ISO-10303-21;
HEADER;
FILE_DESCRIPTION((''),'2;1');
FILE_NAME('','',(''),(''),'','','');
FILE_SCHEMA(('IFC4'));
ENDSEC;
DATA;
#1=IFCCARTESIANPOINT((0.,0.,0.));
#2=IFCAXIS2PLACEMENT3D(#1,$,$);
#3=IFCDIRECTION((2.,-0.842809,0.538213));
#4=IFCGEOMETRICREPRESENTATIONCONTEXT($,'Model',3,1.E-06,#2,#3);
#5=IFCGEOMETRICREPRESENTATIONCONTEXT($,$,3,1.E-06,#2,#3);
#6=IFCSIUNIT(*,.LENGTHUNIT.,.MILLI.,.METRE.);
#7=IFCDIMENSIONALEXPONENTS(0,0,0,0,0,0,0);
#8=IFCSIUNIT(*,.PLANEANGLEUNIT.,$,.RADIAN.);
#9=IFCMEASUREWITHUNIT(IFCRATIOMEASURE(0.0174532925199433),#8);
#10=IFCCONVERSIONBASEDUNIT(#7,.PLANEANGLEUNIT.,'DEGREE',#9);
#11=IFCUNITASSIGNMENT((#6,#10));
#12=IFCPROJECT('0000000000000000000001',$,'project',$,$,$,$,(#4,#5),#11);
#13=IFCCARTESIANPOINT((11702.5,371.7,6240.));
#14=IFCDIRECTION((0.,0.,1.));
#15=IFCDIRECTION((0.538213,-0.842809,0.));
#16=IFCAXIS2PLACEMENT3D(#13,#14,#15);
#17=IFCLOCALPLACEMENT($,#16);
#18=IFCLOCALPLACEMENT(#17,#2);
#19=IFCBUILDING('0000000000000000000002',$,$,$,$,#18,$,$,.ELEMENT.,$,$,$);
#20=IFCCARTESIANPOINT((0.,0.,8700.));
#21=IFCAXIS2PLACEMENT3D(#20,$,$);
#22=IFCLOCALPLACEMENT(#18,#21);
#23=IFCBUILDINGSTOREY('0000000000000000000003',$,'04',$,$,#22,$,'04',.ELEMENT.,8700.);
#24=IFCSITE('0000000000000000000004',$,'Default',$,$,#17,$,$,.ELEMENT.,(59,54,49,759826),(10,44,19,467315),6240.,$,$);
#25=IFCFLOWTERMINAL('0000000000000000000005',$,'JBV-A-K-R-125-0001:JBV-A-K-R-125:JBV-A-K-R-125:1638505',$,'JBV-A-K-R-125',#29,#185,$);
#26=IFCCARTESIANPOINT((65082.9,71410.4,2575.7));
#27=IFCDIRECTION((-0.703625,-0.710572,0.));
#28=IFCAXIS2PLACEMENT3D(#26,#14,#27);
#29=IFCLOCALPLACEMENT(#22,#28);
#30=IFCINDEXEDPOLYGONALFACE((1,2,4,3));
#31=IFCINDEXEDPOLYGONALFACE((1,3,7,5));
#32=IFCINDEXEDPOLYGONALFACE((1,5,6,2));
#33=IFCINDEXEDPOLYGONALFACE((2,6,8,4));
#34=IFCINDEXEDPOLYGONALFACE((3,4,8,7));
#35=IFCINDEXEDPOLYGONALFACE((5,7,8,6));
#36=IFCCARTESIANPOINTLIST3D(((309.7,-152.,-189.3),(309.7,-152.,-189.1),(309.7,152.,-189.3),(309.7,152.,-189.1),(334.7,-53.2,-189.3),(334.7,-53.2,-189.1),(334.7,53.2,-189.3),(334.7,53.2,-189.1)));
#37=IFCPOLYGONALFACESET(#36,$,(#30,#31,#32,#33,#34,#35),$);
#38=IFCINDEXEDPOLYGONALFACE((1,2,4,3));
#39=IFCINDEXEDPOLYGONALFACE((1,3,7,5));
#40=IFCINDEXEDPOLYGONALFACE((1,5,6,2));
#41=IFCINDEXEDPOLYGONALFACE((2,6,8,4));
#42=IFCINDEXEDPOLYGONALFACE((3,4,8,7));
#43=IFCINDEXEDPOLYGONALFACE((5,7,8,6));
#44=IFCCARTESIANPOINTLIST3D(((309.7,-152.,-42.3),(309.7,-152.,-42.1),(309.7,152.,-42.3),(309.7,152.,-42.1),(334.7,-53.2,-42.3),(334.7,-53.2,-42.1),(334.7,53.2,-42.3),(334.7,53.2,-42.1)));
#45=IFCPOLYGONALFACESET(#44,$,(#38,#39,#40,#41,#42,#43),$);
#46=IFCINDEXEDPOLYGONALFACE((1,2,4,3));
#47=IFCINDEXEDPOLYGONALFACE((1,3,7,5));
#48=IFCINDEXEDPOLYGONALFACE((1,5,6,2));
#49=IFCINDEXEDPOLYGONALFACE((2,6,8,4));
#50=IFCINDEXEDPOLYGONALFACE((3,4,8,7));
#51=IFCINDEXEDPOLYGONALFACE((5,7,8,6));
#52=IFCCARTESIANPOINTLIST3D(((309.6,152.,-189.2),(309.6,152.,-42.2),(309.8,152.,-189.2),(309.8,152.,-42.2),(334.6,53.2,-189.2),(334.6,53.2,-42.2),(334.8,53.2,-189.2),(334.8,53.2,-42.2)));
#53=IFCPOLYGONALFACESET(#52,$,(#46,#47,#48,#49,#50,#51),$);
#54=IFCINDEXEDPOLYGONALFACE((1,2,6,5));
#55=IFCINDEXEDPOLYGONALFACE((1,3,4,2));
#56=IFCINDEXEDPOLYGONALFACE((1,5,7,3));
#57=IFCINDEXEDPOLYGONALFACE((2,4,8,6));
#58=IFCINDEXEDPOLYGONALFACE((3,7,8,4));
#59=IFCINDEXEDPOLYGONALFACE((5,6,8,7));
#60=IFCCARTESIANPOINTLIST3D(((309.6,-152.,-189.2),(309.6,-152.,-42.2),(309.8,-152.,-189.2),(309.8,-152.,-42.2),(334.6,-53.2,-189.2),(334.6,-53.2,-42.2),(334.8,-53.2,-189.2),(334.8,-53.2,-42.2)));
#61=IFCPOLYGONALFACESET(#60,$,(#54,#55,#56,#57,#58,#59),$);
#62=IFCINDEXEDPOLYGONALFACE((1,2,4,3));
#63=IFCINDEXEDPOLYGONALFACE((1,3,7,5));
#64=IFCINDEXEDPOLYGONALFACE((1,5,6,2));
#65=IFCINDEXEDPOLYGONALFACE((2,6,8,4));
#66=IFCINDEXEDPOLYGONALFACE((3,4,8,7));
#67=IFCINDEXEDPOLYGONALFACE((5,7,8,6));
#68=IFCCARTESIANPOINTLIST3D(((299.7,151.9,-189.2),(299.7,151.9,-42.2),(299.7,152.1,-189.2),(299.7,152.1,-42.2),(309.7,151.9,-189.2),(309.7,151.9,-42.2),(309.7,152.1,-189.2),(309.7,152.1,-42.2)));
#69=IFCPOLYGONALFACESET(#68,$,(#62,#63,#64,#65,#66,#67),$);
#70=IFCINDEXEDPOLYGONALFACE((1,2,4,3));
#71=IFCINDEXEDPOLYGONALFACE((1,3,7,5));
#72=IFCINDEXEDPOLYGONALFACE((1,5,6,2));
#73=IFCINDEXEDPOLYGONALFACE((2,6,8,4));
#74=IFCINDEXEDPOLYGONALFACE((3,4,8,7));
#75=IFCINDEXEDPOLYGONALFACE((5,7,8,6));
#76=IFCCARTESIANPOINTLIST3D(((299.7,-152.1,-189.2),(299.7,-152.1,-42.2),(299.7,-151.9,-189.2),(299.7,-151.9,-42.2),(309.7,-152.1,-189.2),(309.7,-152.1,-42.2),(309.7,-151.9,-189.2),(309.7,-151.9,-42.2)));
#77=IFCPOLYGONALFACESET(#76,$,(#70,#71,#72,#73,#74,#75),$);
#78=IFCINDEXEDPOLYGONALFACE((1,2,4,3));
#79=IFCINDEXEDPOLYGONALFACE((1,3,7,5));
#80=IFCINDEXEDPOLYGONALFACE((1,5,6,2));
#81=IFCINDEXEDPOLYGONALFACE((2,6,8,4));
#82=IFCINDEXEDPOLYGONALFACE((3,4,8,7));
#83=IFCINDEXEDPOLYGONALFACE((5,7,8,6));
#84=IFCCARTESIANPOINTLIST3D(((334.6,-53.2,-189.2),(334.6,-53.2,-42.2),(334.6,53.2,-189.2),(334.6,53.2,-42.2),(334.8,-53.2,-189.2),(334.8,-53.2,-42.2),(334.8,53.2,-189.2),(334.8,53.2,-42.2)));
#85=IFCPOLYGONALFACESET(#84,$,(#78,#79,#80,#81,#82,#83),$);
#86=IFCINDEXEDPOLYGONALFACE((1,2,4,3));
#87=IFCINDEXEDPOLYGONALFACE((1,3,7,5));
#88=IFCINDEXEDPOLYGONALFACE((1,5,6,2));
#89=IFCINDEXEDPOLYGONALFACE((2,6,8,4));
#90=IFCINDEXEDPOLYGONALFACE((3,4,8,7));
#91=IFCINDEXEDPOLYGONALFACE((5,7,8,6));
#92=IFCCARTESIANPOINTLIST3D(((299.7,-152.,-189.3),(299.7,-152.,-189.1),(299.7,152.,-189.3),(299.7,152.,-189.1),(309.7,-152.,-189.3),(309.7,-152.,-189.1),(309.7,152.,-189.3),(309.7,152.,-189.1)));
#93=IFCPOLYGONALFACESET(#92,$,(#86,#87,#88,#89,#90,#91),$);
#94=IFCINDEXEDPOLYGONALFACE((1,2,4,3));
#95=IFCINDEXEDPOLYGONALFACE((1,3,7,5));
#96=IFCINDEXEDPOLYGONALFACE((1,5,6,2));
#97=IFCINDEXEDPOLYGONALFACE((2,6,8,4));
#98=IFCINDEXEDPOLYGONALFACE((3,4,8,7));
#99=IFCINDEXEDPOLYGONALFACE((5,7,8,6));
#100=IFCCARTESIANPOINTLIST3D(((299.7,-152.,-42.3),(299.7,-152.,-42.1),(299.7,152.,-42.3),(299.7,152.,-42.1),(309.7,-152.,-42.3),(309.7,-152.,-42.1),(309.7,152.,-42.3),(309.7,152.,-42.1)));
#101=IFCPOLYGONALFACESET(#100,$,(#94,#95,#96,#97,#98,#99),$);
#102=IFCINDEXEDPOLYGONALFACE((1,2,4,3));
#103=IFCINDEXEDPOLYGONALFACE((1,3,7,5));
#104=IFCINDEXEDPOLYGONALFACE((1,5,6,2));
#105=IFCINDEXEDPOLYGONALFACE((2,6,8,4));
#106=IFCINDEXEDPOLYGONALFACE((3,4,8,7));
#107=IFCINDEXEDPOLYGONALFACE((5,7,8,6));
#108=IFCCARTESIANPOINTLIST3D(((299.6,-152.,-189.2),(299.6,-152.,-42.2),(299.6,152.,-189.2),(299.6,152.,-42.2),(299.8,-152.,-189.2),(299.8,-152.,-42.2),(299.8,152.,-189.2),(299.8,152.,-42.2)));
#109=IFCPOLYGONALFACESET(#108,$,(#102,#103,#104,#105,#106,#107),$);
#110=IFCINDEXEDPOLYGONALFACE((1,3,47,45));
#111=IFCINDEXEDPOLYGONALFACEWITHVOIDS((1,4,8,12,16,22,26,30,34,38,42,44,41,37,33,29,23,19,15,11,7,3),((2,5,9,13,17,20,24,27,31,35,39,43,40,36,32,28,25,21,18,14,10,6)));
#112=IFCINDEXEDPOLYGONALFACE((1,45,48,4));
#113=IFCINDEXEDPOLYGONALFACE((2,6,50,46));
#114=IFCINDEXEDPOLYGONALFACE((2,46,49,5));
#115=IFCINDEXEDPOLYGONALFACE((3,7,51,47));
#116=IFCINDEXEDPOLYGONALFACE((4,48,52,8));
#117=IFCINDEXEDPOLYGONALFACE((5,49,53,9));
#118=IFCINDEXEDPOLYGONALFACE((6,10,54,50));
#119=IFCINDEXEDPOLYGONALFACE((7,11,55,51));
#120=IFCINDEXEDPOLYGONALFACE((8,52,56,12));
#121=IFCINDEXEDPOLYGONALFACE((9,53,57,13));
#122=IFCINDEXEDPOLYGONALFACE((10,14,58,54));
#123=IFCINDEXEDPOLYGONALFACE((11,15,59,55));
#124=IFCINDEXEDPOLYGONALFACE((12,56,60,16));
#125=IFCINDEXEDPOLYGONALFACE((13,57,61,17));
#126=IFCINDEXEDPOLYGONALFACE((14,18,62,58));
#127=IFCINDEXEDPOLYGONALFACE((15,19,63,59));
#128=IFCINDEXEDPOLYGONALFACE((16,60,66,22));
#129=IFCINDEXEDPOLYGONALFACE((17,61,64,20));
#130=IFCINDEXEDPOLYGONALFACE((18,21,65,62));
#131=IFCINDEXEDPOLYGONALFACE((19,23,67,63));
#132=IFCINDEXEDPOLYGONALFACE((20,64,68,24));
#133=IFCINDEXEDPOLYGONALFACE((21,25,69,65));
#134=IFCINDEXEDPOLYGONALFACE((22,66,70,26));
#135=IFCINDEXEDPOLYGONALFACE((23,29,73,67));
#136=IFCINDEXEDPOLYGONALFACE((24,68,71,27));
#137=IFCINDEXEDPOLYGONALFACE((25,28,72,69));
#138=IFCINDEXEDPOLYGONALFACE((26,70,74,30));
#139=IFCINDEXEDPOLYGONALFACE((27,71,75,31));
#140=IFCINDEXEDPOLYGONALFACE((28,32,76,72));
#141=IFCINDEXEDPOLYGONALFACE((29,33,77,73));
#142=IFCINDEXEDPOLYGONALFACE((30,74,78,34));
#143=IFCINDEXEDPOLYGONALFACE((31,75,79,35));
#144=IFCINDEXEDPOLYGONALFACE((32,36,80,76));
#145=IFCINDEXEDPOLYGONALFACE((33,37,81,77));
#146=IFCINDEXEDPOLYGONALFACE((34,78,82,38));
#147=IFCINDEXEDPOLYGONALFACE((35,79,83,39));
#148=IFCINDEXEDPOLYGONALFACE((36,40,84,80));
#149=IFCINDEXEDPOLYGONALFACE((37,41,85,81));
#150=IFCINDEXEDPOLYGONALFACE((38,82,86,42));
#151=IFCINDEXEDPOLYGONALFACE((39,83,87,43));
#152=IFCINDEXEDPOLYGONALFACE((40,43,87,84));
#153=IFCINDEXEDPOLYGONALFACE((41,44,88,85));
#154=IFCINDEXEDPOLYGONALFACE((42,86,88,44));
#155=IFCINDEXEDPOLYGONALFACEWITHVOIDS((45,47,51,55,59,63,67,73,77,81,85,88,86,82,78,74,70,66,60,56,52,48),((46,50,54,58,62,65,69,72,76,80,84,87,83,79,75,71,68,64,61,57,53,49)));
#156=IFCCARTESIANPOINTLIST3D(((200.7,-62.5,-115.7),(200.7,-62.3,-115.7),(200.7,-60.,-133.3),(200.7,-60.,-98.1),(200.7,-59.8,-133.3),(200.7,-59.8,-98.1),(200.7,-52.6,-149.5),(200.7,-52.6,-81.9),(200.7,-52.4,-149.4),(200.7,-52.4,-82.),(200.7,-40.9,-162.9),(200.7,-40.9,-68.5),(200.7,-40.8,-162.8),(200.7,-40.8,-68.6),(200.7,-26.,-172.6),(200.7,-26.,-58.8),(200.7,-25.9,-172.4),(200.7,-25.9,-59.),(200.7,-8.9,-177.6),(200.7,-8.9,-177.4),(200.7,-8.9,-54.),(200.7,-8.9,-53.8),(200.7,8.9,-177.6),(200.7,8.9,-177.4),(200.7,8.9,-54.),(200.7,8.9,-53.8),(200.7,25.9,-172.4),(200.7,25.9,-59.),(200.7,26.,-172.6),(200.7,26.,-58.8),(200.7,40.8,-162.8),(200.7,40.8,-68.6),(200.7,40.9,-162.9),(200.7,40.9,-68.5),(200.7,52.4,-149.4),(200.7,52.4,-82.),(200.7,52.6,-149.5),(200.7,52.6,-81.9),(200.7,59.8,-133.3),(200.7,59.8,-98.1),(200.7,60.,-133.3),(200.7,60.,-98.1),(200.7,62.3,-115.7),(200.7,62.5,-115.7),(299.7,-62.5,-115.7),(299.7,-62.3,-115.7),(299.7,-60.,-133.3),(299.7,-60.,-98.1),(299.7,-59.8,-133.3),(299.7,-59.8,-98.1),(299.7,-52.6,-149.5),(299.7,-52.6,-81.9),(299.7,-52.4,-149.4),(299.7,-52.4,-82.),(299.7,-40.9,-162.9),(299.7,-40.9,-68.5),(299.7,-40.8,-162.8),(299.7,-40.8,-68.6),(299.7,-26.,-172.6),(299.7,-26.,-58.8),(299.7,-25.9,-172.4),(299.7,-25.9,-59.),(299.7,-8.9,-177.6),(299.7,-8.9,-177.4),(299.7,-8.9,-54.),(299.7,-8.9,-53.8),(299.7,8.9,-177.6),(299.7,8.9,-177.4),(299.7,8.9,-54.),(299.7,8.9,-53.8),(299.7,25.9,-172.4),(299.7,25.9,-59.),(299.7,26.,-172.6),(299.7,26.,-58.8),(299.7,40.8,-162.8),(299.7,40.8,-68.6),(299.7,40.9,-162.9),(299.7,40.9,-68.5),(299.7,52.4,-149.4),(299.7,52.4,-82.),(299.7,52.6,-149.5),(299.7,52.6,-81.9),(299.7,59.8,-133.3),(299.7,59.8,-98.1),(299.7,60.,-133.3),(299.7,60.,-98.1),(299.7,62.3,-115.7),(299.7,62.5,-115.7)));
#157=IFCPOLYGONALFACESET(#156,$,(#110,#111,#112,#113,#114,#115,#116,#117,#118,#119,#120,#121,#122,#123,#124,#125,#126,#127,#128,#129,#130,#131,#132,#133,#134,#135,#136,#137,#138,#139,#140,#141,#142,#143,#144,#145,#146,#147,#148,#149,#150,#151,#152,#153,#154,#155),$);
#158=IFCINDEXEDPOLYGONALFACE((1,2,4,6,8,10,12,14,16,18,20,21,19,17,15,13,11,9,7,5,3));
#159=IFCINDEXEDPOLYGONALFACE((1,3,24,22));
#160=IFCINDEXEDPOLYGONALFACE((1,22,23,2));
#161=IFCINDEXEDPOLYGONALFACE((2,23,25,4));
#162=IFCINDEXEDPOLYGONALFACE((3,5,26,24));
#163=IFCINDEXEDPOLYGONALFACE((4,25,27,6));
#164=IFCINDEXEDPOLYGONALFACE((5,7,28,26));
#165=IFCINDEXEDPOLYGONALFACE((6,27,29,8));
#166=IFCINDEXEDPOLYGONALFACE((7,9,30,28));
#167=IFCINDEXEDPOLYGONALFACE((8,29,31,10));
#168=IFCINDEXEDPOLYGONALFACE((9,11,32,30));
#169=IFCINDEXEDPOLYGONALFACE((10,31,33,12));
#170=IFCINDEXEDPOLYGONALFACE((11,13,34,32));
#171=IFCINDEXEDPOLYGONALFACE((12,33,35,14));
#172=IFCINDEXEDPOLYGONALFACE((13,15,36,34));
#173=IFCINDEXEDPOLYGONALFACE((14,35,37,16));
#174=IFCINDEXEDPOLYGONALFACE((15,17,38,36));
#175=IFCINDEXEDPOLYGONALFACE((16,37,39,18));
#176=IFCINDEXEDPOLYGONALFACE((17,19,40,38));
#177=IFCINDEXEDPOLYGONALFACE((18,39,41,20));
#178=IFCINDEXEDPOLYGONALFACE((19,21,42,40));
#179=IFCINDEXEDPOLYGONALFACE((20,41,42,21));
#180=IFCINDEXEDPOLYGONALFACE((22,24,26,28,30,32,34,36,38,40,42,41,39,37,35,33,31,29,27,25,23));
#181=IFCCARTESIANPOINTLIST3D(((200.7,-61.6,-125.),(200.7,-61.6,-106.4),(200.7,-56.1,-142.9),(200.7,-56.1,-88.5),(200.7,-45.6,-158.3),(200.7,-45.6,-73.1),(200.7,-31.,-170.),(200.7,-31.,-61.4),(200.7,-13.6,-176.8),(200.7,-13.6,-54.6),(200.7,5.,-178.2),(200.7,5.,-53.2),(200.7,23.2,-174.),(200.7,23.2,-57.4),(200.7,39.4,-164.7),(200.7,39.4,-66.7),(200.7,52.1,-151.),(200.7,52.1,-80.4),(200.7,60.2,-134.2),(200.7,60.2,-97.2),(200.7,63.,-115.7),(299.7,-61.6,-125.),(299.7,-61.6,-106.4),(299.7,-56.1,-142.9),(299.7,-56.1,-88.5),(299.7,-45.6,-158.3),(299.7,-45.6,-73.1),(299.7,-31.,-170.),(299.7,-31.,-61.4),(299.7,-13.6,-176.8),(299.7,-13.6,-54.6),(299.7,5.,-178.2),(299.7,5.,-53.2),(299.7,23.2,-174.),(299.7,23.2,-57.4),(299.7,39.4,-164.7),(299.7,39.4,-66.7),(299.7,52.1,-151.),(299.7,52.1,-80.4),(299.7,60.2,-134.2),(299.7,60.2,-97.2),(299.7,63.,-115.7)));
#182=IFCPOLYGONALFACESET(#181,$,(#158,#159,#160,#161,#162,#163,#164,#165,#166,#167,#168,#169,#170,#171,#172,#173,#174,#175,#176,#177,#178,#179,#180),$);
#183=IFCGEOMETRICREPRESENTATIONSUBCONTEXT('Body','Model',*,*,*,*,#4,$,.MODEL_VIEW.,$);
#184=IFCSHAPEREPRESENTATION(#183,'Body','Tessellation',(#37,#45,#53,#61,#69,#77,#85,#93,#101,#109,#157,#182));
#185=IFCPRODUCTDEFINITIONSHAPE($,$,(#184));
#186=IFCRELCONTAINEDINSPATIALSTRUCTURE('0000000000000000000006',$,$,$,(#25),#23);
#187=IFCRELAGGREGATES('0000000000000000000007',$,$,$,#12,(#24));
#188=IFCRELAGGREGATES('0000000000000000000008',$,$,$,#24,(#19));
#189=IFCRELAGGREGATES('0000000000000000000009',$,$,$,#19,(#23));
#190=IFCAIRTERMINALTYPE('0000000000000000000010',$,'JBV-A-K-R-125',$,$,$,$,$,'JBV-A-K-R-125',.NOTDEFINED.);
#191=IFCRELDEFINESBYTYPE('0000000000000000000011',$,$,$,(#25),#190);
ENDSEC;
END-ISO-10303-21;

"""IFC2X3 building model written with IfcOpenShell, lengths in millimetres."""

from ifc_helpers import new_model, entity, si_unit, converted_unit, direction, frame, frame_2d, origin, origin_2d_with_axis, place, context, subcontext, project, spatial, polyline, circle_curve, parameter, trimmed, segment, composite_curve, rectangle, circle, outline, extrude, source, transform, mapped, type_object, type_shapes, element, save


model = new_model("IFC2X3")

# Units and contexts
model_context = context("Model", 3, precision=1e-06, world=origin(), true_north=direction((2.0, -0.842809, 0.538213)))
context_of_model = context(None, 3, precision=1e-06, world=origin(), true_north=direction((2.0, -0.842809, 0.538213)))
body_context = subcontext(model_context, "Body", "Model", "MODEL_VIEW")
ifc_project = project(units=[si_unit("LENGTHUNIT", "METRE", prefix="MILLI"), converted_unit("PLANEANGLEUNIT", "DEGREE", entity("IfcRatioMeasure", 0.0174532925199433), si_unit("PLANEANGLEUNIT", "RADIAN"), dimensions=[0, 0, 0, 0, 0, 0, 0])], contexts=[model_context, context_of_model])

# Site, building, storey
site_placement = place(None, frame((11702.5, 371.7, 6240.0), z_axis=(0.0, 0.0, 1.0), x_axis=(0.538213, -0.842809, 0.0)))
site = spatial("IfcSite", under=ifc_project, at=site_placement, Name="Default", CompositionType="ELEMENT", RefLatitude=(59, 54, 49, 759826), RefLongitude=(10, 44, 19, 467315), RefElevation=6240.0)
building_placement = place(site_placement, origin())
building = spatial("IfcBuilding", under=site, at=building_placement, CompositionType="ELEMENT")
storey_placement = place(building_placement, frame((0.0, 0.0, 8700.0)))
storey = spatial("IfcBuildingStorey", under=building, at=storey_placement, Name="04", LongName="04", CompositionType="ELEMENT", Elevation=8700.0)

# Flow terminal
air_terminal_type_1 = type_object("IfcAirTerminalType", Name="JBV-A-K-R-125", ElementType="JBV-A-K-R-125", PredefinedType="NOTDEFINED")
shared_shape_1 = source(origin(), body_context, "Body", "SweptSolid", [
    extrude(outline(polyline([(-152.0, -12.5), (152.0, -12.5), (53.2, 12.5), (-53.2, 12.5), (-152.0, -12.5)])), frame((322.2, 0.0, -189.3), z_axis=(0.0, 0.0, 1.0), x_axis=(0.0, -1.0, 0.0)), (0.0, 0.0, 1.0), 0.2),
    extrude(outline(polyline([(-152.0, -12.5), (152.0, -12.5), (53.2, 12.5), (-53.2, 12.5), (-152.0, -12.5)])), frame((322.2, 0.0, -42.3), z_axis=(0.0, 0.0, 1.0), x_axis=(0.0, -1.0, 0.0)), (0.0, 0.0, 1.0), 0.2),
    extrude(rectangle(XDim=0.2, YDim=101.9, at=frame_2d((0.0, 0.0), x_axis=(1.0, 0.0))), frame((322.2, 102.6, -189.2), z_axis=(0.0, 0.0, 1.0), x_axis=(0.969446, 0.245305, 0.0)), (0.0, 0.0, 1.0), 147.0),
    extrude(rectangle(XDim=0.2, YDim=101.9, at=frame_2d((0.0, 0.0), x_axis=(1.0, 0.0))), frame((322.2, -102.6, -189.2), z_axis=(0.0, 0.0, 1.0), x_axis=(-0.969446, 0.245305, 0.0)), (0.0, 0.0, 1.0), 147.0),
    extrude(rectangle(XDim=0.2, YDim=10.0, at=frame_2d((0.0, 0.0), x_axis=(1.0, 0.0))), frame((304.7, 152.0, -189.2), z_axis=(0.0, 0.0, 1.0), x_axis=(0.0, 1.0, 0.0)), (0.0, 0.0, 1.0), 147.0),
    extrude(rectangle(XDim=0.2, YDim=10.0, at=frame_2d((0.0, 0.0), x_axis=(1.0, 0.0))), frame((304.7, -152.0, -189.2), z_axis=(0.0, 0.0, 1.0), x_axis=(0.0, 1.0, 0.0)), (0.0, 0.0, 1.0), 147.0),
    extrude(rectangle(XDim=0.2, YDim=106.4, at=frame_2d((0.0, 0.0), x_axis=(1.0, 0.0))), frame((334.7, 0.0, -189.2)), (0.0, 0.0, 1.0), 147.0),
    extrude(rectangle(XDim=304.0, YDim=10.0, at=frame_2d((0.0, 0.0), x_axis=(1.0, 0.0))), frame((304.7, 0.0, -189.3), z_axis=(0.0, 0.0, 1.0), x_axis=(0.0, -1.0, 0.0)), (0.0, 0.0, 1.0), 0.2),
    extrude(rectangle(XDim=304.0, YDim=10.0, at=frame_2d((0.0, 0.0), x_axis=(1.0, 0.0))), frame((304.7, 0.0, -42.3), z_axis=(0.0, 0.0, 1.0), x_axis=(0.0, -1.0, 0.0)), (0.0, 0.0, 1.0), 0.2),
    extrude(rectangle(XDim=0.2, YDim=304.0, at=frame_2d((0.0, 0.0), x_axis=(1.0, 0.0))), frame((299.7, 0.0, -189.2)), (0.0, 0.0, 1.0), 147.0),
    extrude(outline(composite_curve([segment(trimmed(circle_curve(origin_2d_with_axis(), 62.5), [parameter(0.0)], [parameter(180.0)], True, "PARAMETER"), True, "CONTINUOUS"), segment(trimmed(circle_curve(origin_2d_with_axis(), 62.5), [parameter(180.0)], [parameter(360.0)], True, "PARAMETER"), True, "CONTINUOUS")], self_intersect=False), holes=[composite_curve([segment(trimmed(circle_curve(origin_2d_with_axis(), 62.3), [parameter(180.0)], [parameter(360.0)], True, "PARAMETER"), False, "CONTINUOUS"), segment(trimmed(circle_curve(origin_2d_with_axis(), 62.3), [parameter(0.0)], [parameter(180.0)], True, "PARAMETER"), False, "CONTINUOUS")], self_intersect=False)]), frame((200.7, 0.0, -115.7), z_axis=(1.0, 0.0, 0.0), x_axis=(0.0, 1.0, 0.0)), (0.0, 0.0, 1.0), 99.0),
    extrude(circle(Radius=62.6, at=frame_2d((0.0, 0.0), x_axis=(1.0, 0.0))), frame((200.7, 0.3, -115.7), z_axis=(1.0, 0.0, 0.0), x_axis=(0.0, 1.0, 0.0)), (0.0, 0.0, 1.0), 99.0),
])
type_shapes(air_terminal_type_1, [shared_shape_1])
flow_terminal_1_placement = place(storey_placement, frame((65082.9, 71410.4, 2575.7), z_axis=(0.0, 0.0, 1.0), x_axis=(-0.703625, -0.710572, 0.0)))
element("IfcFlowTerminal", 1, at=flow_terminal_1_placement, inside=storey, type_object=air_terminal_type_1, Name="JBV-A-K-R-125-0001:JBV-A-K-R-125:JBV-A-K-R-125:1638505", ObjectType="JBV-A-K-R-125", context=body_context, shape_type="MappedRepresentation", body=[
    mapped(shared_shape_1, transform((0.0, 0.0, 0.0), scale=1.0)),
])

save(model, "model.ifc")
